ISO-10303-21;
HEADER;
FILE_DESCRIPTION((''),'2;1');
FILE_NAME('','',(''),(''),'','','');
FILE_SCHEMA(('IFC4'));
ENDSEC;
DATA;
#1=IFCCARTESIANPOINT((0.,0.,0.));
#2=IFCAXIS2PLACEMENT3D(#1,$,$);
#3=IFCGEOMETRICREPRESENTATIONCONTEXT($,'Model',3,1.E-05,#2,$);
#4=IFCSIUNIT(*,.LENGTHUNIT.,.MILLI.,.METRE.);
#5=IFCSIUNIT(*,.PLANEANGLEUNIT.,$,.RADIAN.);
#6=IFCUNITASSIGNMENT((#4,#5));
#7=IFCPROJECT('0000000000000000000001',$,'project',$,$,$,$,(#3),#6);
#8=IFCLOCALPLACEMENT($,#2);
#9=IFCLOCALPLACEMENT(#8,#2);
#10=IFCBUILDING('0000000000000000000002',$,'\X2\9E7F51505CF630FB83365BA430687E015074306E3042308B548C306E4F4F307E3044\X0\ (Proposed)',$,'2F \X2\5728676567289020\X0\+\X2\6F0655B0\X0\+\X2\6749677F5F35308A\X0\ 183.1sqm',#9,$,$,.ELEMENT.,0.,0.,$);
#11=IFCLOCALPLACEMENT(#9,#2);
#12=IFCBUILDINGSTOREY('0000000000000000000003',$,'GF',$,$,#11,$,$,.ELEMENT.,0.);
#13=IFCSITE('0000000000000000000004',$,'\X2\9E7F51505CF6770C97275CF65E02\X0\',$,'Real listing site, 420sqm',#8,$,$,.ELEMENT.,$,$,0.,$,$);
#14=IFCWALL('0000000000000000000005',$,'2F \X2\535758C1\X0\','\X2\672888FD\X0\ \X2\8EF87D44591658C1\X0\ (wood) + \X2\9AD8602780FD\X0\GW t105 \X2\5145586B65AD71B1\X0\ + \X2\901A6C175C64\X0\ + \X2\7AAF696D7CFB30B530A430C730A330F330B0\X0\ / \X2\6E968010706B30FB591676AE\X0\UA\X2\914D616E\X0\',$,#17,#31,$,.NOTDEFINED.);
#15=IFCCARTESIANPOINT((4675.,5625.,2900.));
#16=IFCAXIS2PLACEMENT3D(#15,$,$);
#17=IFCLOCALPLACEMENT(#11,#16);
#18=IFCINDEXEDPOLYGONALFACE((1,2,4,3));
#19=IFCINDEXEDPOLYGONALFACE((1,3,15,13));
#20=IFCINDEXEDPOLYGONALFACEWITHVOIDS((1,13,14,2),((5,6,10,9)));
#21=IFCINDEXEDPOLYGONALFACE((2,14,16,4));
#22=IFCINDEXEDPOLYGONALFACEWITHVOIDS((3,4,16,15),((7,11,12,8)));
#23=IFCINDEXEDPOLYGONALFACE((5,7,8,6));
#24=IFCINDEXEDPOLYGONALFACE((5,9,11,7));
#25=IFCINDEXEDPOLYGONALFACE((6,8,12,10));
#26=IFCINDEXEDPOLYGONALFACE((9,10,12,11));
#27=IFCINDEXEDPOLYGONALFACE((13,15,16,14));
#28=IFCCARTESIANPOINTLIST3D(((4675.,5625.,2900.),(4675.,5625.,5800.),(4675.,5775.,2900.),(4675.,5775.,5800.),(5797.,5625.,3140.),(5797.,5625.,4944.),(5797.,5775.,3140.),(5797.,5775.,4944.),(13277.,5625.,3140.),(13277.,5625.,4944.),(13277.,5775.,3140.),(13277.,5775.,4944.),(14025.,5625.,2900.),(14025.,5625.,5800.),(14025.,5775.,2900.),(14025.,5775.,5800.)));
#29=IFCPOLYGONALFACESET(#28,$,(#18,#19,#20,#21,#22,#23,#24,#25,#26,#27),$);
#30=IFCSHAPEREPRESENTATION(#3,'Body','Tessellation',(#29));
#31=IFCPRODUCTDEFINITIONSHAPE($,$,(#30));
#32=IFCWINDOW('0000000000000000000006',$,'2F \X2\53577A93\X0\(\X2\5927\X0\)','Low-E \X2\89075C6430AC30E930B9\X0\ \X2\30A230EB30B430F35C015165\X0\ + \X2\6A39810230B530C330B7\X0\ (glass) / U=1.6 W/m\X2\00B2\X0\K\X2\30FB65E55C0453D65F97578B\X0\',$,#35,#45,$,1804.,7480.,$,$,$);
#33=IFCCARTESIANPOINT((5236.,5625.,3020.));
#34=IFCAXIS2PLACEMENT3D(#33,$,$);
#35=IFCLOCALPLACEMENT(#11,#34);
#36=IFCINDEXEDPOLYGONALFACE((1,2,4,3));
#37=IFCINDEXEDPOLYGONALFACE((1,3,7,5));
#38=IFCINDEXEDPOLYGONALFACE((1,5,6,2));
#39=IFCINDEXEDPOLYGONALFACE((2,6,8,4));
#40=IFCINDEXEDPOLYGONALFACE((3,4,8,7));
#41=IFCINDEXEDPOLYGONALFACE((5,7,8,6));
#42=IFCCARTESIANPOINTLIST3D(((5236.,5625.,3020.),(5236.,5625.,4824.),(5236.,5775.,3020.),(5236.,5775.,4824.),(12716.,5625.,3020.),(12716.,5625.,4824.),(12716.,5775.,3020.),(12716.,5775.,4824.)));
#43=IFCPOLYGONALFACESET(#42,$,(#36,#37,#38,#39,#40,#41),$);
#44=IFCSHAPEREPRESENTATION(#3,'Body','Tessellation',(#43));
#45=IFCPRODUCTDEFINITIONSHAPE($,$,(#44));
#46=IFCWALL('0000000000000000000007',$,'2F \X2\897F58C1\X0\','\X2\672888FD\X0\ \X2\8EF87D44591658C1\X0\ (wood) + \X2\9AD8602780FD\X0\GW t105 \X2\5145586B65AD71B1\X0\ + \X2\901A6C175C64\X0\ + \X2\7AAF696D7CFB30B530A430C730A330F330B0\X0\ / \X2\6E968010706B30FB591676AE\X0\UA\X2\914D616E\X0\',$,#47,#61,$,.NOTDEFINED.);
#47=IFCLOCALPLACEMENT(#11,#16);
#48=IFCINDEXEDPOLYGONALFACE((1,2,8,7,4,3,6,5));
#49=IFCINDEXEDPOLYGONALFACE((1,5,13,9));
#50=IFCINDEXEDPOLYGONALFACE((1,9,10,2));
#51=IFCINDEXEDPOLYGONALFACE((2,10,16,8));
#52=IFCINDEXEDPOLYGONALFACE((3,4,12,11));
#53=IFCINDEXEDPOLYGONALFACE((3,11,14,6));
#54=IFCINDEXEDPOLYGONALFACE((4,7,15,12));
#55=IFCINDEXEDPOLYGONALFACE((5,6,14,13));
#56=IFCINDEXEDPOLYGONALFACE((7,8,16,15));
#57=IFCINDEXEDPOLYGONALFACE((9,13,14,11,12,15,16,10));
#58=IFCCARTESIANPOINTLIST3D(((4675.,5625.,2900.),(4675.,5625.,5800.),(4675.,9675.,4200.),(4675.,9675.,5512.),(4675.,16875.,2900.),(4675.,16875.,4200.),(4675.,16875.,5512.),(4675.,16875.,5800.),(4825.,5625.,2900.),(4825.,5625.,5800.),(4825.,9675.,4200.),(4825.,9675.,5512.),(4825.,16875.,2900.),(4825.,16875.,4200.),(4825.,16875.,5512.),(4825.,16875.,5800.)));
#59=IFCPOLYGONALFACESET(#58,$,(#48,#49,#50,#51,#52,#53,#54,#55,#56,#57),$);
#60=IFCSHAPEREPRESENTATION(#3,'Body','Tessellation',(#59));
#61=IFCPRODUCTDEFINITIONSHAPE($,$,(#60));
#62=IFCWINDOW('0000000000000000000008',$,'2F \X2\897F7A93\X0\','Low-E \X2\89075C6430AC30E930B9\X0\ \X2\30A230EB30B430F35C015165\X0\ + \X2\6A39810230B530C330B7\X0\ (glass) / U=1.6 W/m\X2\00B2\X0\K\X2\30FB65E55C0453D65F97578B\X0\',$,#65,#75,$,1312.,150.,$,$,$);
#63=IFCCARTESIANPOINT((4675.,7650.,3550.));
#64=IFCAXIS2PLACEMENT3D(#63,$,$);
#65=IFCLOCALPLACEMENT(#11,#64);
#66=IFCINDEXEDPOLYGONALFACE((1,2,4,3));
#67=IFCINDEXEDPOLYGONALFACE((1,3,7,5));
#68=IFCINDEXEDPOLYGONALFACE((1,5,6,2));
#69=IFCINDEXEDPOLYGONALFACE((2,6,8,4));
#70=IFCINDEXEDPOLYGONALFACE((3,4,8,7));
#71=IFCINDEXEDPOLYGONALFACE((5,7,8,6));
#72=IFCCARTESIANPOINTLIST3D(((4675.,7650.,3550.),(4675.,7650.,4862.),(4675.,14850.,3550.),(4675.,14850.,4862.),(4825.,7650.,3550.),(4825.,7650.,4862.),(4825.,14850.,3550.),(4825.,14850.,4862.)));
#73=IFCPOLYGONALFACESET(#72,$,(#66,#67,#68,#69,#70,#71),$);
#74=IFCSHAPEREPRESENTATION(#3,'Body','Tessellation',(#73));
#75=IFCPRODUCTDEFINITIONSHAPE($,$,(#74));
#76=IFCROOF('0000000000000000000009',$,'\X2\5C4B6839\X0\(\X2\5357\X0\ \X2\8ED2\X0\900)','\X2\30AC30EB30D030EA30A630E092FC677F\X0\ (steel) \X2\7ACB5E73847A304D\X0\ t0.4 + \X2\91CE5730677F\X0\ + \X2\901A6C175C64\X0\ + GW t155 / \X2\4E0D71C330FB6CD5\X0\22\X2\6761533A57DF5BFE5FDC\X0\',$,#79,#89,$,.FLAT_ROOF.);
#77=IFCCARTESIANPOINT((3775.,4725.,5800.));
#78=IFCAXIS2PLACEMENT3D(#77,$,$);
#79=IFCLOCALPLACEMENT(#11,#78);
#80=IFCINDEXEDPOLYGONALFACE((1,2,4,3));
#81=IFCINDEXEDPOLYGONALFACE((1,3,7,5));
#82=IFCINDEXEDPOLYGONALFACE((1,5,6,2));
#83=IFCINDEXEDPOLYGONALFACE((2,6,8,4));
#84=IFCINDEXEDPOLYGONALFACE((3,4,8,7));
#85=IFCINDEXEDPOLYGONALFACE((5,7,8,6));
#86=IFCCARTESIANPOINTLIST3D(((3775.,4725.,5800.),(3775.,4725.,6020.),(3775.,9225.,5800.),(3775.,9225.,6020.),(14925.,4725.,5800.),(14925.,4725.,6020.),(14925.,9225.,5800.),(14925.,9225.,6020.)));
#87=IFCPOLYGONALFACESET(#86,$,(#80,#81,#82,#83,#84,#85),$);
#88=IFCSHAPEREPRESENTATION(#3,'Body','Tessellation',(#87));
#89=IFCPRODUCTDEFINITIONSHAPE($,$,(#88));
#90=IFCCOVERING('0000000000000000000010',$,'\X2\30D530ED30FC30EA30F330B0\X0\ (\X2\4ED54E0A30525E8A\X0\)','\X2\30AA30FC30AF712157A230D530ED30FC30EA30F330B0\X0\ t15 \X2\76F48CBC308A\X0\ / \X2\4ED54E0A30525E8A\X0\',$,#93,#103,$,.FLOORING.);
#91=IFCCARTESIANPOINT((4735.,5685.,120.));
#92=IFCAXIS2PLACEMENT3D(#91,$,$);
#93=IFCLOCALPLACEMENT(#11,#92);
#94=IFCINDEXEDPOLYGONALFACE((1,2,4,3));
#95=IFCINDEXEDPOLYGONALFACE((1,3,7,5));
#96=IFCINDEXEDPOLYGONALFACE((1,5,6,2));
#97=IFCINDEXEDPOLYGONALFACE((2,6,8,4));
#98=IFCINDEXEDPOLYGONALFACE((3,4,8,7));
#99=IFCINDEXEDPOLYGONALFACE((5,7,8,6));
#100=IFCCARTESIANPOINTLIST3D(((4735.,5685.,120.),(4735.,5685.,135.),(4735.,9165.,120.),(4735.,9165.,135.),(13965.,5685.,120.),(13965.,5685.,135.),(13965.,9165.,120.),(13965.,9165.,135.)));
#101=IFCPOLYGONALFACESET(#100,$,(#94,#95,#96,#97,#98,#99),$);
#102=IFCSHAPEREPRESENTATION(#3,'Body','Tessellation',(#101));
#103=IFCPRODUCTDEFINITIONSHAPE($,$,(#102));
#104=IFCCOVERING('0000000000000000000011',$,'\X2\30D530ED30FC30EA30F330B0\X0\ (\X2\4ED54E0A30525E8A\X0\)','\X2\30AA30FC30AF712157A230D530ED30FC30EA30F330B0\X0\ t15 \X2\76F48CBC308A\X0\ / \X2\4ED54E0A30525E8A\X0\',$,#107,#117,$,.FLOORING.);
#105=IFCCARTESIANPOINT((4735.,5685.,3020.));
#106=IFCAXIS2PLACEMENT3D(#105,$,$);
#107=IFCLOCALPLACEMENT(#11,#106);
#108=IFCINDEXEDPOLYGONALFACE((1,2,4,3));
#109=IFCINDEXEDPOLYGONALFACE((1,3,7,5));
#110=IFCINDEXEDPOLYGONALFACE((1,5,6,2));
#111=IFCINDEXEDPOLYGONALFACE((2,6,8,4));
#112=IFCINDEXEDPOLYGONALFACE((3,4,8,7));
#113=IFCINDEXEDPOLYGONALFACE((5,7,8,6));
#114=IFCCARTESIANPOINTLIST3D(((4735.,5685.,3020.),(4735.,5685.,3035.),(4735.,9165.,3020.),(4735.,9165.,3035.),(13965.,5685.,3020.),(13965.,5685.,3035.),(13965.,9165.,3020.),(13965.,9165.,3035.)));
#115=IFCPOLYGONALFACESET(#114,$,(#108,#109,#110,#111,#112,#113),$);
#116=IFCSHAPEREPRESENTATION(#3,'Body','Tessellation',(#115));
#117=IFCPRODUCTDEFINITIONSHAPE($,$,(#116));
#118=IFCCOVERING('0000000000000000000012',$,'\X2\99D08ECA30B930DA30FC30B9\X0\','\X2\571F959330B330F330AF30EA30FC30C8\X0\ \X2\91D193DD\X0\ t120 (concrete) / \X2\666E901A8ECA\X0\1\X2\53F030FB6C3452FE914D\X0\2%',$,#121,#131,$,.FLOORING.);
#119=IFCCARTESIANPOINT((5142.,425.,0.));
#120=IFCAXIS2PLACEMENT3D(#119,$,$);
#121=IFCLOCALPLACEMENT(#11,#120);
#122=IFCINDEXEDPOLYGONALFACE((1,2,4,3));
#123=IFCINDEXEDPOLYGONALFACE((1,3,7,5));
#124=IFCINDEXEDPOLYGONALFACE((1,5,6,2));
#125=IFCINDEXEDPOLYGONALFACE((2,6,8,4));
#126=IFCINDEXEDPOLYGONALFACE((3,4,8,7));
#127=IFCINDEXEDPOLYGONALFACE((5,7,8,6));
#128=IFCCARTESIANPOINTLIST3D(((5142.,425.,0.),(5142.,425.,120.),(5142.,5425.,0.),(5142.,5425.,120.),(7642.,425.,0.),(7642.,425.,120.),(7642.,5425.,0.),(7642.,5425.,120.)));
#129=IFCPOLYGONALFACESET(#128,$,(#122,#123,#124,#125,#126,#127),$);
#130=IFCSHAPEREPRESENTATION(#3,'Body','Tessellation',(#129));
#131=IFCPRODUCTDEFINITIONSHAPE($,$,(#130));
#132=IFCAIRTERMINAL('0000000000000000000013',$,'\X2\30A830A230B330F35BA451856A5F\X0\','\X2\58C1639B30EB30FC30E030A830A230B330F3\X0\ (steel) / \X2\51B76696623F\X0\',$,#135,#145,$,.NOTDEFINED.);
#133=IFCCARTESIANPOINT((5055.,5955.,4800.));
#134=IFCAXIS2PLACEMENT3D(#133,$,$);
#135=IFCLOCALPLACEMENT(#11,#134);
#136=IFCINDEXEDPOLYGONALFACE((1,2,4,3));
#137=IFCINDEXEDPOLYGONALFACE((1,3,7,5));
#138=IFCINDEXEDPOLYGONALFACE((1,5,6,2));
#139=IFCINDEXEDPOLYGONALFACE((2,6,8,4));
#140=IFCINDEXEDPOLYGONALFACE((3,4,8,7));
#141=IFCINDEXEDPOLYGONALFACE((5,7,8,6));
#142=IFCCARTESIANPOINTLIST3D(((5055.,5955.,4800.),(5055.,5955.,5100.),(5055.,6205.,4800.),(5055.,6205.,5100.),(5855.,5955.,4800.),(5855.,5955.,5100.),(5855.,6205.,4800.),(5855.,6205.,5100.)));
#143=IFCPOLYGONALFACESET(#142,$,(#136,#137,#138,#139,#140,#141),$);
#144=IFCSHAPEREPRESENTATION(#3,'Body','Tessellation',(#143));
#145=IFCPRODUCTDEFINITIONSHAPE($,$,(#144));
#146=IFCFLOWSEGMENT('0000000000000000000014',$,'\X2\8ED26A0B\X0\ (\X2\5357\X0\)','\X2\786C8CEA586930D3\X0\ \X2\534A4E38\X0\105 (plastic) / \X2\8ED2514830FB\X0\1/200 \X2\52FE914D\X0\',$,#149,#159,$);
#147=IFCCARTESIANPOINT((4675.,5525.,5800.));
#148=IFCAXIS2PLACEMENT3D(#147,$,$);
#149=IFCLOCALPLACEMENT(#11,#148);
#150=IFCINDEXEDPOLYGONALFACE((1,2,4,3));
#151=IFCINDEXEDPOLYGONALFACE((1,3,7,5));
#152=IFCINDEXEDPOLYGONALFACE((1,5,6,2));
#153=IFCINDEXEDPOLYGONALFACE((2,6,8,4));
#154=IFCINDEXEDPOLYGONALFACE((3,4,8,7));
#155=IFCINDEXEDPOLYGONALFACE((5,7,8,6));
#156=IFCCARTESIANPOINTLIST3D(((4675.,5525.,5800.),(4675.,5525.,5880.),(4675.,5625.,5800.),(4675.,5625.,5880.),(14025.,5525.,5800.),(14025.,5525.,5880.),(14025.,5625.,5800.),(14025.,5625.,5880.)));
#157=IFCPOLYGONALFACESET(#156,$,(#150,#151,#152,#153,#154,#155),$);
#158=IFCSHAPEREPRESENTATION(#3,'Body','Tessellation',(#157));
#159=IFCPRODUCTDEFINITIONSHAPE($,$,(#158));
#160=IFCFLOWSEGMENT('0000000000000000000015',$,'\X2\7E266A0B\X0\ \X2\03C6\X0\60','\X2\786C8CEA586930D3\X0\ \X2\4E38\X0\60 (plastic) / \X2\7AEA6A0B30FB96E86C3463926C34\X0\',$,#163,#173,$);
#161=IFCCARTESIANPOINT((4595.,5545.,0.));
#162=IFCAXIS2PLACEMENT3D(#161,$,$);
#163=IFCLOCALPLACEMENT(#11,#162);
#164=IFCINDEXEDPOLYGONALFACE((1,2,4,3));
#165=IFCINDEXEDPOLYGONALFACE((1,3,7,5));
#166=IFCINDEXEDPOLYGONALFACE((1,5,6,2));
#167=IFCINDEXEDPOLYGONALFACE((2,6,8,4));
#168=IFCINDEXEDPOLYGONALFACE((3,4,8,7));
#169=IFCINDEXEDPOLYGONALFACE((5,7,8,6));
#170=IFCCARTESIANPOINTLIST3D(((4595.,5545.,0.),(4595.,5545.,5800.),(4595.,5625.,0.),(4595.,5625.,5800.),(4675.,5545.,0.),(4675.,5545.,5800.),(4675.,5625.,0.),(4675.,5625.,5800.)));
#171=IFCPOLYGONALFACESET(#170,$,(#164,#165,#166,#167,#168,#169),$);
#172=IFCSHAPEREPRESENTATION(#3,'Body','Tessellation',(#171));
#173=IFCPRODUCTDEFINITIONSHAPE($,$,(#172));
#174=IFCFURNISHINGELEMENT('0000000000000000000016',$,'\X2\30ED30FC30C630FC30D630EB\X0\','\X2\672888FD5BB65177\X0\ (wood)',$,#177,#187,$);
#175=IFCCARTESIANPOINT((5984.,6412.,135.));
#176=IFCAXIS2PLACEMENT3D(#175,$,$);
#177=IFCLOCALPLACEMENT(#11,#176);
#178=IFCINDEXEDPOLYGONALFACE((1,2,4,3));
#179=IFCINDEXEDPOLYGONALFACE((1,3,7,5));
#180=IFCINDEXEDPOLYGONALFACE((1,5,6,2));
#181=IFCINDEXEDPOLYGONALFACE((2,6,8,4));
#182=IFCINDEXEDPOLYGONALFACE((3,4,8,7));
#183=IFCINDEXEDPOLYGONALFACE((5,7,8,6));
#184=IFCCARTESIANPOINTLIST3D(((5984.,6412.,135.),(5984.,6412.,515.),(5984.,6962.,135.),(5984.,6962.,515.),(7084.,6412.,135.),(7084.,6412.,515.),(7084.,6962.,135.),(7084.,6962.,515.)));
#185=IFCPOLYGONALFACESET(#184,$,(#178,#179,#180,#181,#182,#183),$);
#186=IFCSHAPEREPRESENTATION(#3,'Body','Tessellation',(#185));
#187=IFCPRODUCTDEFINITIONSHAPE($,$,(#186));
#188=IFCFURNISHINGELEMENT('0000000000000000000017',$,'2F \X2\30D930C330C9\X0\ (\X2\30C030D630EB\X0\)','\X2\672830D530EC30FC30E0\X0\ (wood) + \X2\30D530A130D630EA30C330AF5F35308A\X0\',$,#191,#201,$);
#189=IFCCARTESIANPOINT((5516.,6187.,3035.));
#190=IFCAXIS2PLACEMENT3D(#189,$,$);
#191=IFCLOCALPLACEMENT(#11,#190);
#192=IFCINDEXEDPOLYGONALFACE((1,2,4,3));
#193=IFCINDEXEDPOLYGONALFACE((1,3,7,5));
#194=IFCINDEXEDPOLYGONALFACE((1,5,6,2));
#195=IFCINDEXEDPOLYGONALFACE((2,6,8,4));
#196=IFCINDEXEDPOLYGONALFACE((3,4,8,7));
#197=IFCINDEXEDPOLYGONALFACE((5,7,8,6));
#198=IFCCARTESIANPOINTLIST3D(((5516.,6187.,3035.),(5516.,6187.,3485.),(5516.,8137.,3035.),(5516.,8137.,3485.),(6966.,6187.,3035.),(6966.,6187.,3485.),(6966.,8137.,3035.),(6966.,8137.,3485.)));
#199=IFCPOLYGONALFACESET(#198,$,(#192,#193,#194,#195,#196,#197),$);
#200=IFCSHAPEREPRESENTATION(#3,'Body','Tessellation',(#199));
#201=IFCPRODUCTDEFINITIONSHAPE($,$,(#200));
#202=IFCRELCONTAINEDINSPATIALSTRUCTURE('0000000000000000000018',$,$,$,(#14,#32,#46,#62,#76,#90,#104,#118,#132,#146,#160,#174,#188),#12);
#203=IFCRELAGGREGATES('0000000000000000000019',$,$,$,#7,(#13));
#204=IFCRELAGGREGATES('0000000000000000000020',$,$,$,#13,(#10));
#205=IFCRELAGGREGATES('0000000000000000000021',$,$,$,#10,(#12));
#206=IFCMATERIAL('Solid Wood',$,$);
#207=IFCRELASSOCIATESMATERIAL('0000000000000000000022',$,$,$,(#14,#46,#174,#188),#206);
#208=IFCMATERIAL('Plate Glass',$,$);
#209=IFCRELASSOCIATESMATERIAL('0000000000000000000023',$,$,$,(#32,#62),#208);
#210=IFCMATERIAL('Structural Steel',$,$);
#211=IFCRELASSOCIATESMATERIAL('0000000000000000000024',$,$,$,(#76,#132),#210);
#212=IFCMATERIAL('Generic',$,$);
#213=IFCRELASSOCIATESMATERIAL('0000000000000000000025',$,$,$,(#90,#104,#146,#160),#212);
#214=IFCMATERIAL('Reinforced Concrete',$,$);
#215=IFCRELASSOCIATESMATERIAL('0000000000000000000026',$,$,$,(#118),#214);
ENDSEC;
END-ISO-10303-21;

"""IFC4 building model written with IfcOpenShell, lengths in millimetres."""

from ifc_helpers import new_model, si_unit, frame, frame_2d, origin, place, context, project, spatial, rectangle, extrude, material, element, fill, save


model = new_model("IFC4")

# Units and contexts
model_context = context("Model", 3, precision=1e-05, world=origin())
ifc_project = project(units=[si_unit("LENGTHUNIT", "METRE", prefix="MILLI"), si_unit("PLANEANGLEUNIT", "RADIAN")], contexts=[model_context])

# Site, building, storey
site_placement = place(None, origin())
site = spatial("IfcSite", under=ifc_project, at=site_placement, Name="鹿児島県霧島市", ObjectType="Real listing site, 420sqm", CompositionType="ELEMENT", RefElevation=0.0)
building_placement = place(site_placement, origin())
building = spatial("IfcBuilding", under=site, at=building_placement, Name="鹿児島・茶室と縁側のある和の住まい (Proposed)", ObjectType="2F 在来木造+漆喰+杉板張り 183.1sqm", CompositionType="ELEMENT", ElevationOfRefHeight=0.0, ElevationOfTerrain=0.0)
storey_placement = place(building_placement, origin())
storey = spatial("IfcBuildingStorey", under=building, at=storey_placement, Name="GF", CompositionType="ELEMENT", Elevation=0.0)

# Shared definitions
ifc_material_1 = material(Name="Solid Wood")

# Shared definitions
ifc_material_2 = material(Name="Reinforced Concrete")

# Shared definitions
ifc_material_3 = material(Name="Plate Glass")

# Walls, openings, windows
wall_1_placement = place(storey_placement, frame((4675.0, 5625.0, 2900.0)))
wall_1 = element("IfcWall", 1, at=wall_1_placement, inside=storey, material=ifc_material_1, Name="2F 南壁", Description="木製 軸組外壁 (wood) + 高性能GW t105 充填断熱 + 通気層 + 窯業系サイディング / 準耐火・外皮UA配慮", PredefinedType="NOTDEFINED", context=model_context, shape_type="SweptSolid", body=[
    extrude(rectangle(XDim=9350.0, YDim=150.0, at=frame_2d((4675.0, 75.0))), frame((4675.0, 5625.0, 2900.0)), (0.0, 0.0, 1.0), 2900.0),
])
opening_1_placement = place(storey_placement, frame((5236.0, 5625.0, 3020.0)))
opening_1 = element("IfcOpeningElement", 2, at=opening_1_placement, cuts=wall_1, PredefinedType="NOTDEFINED", context=model_context, shape_type="SweptSolid", body=[
    extrude(rectangle(XDim=7480.0, YDim=150.0, at=frame_2d((3740.0, 75.0))), frame((5236.0, 5625.0, 3020.0)), (0.0, 0.0, 1.0), 1804.0),
])
window_1_placement = place(storey_placement, frame((5236.0, 5625.0, 3020.0)))
window_1 = element("IfcWindow", 3, at=window_1_placement, inside=storey, material=ifc_material_3, Name="2F 南窓(大)", Description="Low-E 複層ガラス アルゴン封入 + 樹脂サッシ (glass) / U=1.6 W/m²K・日射取得型", OverallHeight=1804.0, OverallWidth=7480.0, context=model_context, shape_type="SweptSolid", body=[
    extrude(rectangle(XDim=7480.0, YDim=150.0, at=frame_2d((3740.0, 75.0))), frame((5236.0, 5625.0, 3020.0)), (0.0, 0.0, 1.0), 1804.0),
])
fill(opening_1, window_1)
wall_2_placement = place(storey_placement, frame((4675.0, 5625.0, 2900.0)))
wall_2 = element("IfcWall", 4, at=wall_2_placement, inside=storey, material=ifc_material_1, Name="2F 西壁", Description="木製 軸組外壁 (wood) + 高性能GW t105 充填断熱 + 通気層 + 窯業系サイディング / 準耐火・外皮UA配慮", PredefinedType="NOTDEFINED", context=model_context, shape_type="SweptSolid", body=[
    extrude(rectangle(XDim=150.0, YDim=11250.0, at=frame_2d((75.0, 5625.0))), frame((4675.0, 5625.0, 2900.0)), (0.0, 0.0, 1.0), 2900.0),
])
opening_2_placement = place(storey_placement, frame((4675.0, 7650.0, 3550.0)))
opening_2 = element("IfcOpeningElement", 5, at=opening_2_placement, cuts=wall_2, PredefinedType="NOTDEFINED", context=model_context, shape_type="SweptSolid", body=[
    extrude(rectangle(XDim=150.0, YDim=7200.0, at=frame_2d((75.0, 3600.0))), frame((4675.0, 7650.0, 3550.0)), (0.0, 0.0, 1.0), 1312.0),
])
window_2_placement = place(storey_placement, frame((4675.0, 7650.0, 3550.0)))
window_2 = element("IfcWindow", 6, at=window_2_placement, inside=storey, material=ifc_material_3, Name="2F 西窓", Description="Low-E 複層ガラス アルゴン封入 + 樹脂サッシ (glass) / U=1.6 W/m²K・日射取得型", OverallHeight=1312.0, OverallWidth=150.0, context=model_context, shape_type="SweptSolid", body=[
    extrude(rectangle(XDim=150.0, YDim=7200.0, at=frame_2d((75.0, 3600.0))), frame((4675.0, 7650.0, 3550.0)), (0.0, 0.0, 1.0), 1312.0),
])
fill(opening_2, window_2)

# Roof
ifc_material_4 = material(Name="Structural Steel")
for number, where, name in (
    (7, (3775.0, 4725.0, 5800.0), "屋根(南 軒900)"),
):
    element("IfcRoof", number, at=place(storey_placement, frame(where)), inside=storey, material=ifc_material_4, Name=name, Description="ガルバリウム鋼板 (steel) 立平葺き t0.4 + 野地板 + 通気層 + GW t155 / 不燃・法22条区域対応", PredefinedType="FLAT_ROOF", context=model_context, shape_type="SweptSolid", body=[
        extrude(rectangle(XDim=11150.0, YDim=4500.0, at=frame_2d((5575.0, 2250.0))), frame((3775.0, 4725.0, 5800.0)), (0.0, 0.0, 1.0), 220.0),
    ])

# Coverings
ifc_material_5 = material(Name="Generic")
covering_1_placement = place(storey_placement, frame((4735.0, 5685.0, 120.0)))
element("IfcCovering", 8, at=covering_1_placement, inside=storey, material=ifc_material_5, Name="フローリング (仕上げ床)", Description="オーク無垢フローリング t15 直貼り / 仕上げ床", PredefinedType="FLOORING", context=model_context, shape_type="SweptSolid", body=[
    extrude(rectangle(XDim=9230.0, YDim=3480.0, at=frame_2d((4615.0, 1740.0))), frame((4735.0, 5685.0, 120.0)), (0.0, 0.0, 1.0), 15.0),
])
covering_2_placement = place(storey_placement, frame((4735.0, 5685.0, 3020.0)))
element("IfcCovering", 9, at=covering_2_placement, inside=storey, material=ifc_material_5, Name="フローリング (仕上げ床)", Description="オーク無垢フローリング t15 直貼り / 仕上げ床", PredefinedType="FLOORING", context=model_context, shape_type="SweptSolid", body=[
    extrude(rectangle(XDim=9230.0, YDim=3480.0, at=frame_2d((4615.0, 1740.0))), frame((4735.0, 5685.0, 3020.0)), (0.0, 0.0, 1.0), 15.0),
])
covering_3_placement = place(storey_placement, frame((5142.0, 425.0, 0.0)))
element("IfcCovering", 10, at=covering_3_placement, inside=storey, material=ifc_material_2, Name="駐車スペース", Description="土間コンクリート 金鏝 t120 (concrete) / 普通車1台・水勾配2%", PredefinedType="FLOORING", context=model_context, shape_type="SweptSolid", body=[
    extrude(rectangle(XDim=2500.0, YDim=5000.0, at=frame_2d((1250.0, 2500.0))), frame((5142.0, 425.0, 0.0)), (0.0, 0.0, 1.0), 120.0),
])

# Air terminal
air_terminal_placement = place(storey_placement, frame((5055.0, 5955.0, 4800.0)))
element("IfcAirTerminal", 11, at=air_terminal_placement, inside=storey, material=ifc_material_4, Name="エアコン室内機", Description="壁掛ルームエアコン (steel) / 冷暖房", PredefinedType="NOTDEFINED", context=model_context, shape_type="SweptSolid", body=[
    extrude(rectangle(XDim=800.0, YDim=250.0, at=frame_2d((400.0, 125.0))), frame((5055.0, 5955.0, 4800.0)), (0.0, 0.0, 1.0), 300.0),
])

# Flow segments
flow_segment_1_placement = place(storey_placement, frame((4675.0, 5525.0, 5800.0)))
element("IfcFlowSegment", 12, at=flow_segment_1_placement, inside=storey, material=ifc_material_5, Name="軒樋 (南)", Description="硬質塩ビ 半丸105 (plastic) / 軒先・1/200 勾配", context=model_context, shape_type="SweptSolid", body=[
    extrude(rectangle(XDim=9350.0, YDim=100.0, at=frame_2d((4675.0, 50.0))), frame((4675.0, 5525.0, 5800.0)), (0.0, 0.0, 1.0), 80.0),
])
flow_segment_2_placement = place(storey_placement, frame((4595.0, 5545.0, 0.0)))
element("IfcFlowSegment", 13, at=flow_segment_2_placement, inside=storey, material=ifc_material_5, Name="縦樋 φ60", Description="硬質塩ビ 丸60 (plastic) / 竪樋・雨水排水", context=model_context, shape_type="SweptSolid", body=[
    extrude(rectangle(XDim=80.0, YDim=80.0, at=frame_2d((40.0, 40.0))), frame((4595.0, 5545.0, 0.0)), (0.0, 0.0, 1.0), 5800.0),
])

# Furnishing elements
furnishing_1_placement = place(storey_placement, frame((5984.0, 6412.0, 135.0)))
element("IfcFurnishingElement", 14, at=furnishing_1_placement, inside=storey, material=ifc_material_1, Name="ローテーブル", Description="木製家具 (wood)", context=model_context, shape_type="SweptSolid", body=[
    extrude(rectangle(XDim=1100.0, YDim=550.0, at=frame_2d((550.0, 275.0))), frame((5984.0, 6412.0, 135.0)), (0.0, 0.0, 1.0), 380.0),
])
furnishing_2_placement = place(storey_placement, frame((5516.0, 6187.0, 3035.0)))
element("IfcFurnishingElement", 15, at=furnishing_2_placement, inside=storey, material=ifc_material_1, Name="2F ベッド (ダブル)", Description="木フレーム (wood) + ファブリック張り", context=model_context, shape_type="SweptSolid", body=[
    extrude(rectangle(XDim=1450.0, YDim=1950.0, at=frame_2d((725.0, 975.0))), frame((5516.0, 6187.0, 3035.0)), (0.0, 0.0, 1.0), 450.0),
])

save(model, "model.ifc")
